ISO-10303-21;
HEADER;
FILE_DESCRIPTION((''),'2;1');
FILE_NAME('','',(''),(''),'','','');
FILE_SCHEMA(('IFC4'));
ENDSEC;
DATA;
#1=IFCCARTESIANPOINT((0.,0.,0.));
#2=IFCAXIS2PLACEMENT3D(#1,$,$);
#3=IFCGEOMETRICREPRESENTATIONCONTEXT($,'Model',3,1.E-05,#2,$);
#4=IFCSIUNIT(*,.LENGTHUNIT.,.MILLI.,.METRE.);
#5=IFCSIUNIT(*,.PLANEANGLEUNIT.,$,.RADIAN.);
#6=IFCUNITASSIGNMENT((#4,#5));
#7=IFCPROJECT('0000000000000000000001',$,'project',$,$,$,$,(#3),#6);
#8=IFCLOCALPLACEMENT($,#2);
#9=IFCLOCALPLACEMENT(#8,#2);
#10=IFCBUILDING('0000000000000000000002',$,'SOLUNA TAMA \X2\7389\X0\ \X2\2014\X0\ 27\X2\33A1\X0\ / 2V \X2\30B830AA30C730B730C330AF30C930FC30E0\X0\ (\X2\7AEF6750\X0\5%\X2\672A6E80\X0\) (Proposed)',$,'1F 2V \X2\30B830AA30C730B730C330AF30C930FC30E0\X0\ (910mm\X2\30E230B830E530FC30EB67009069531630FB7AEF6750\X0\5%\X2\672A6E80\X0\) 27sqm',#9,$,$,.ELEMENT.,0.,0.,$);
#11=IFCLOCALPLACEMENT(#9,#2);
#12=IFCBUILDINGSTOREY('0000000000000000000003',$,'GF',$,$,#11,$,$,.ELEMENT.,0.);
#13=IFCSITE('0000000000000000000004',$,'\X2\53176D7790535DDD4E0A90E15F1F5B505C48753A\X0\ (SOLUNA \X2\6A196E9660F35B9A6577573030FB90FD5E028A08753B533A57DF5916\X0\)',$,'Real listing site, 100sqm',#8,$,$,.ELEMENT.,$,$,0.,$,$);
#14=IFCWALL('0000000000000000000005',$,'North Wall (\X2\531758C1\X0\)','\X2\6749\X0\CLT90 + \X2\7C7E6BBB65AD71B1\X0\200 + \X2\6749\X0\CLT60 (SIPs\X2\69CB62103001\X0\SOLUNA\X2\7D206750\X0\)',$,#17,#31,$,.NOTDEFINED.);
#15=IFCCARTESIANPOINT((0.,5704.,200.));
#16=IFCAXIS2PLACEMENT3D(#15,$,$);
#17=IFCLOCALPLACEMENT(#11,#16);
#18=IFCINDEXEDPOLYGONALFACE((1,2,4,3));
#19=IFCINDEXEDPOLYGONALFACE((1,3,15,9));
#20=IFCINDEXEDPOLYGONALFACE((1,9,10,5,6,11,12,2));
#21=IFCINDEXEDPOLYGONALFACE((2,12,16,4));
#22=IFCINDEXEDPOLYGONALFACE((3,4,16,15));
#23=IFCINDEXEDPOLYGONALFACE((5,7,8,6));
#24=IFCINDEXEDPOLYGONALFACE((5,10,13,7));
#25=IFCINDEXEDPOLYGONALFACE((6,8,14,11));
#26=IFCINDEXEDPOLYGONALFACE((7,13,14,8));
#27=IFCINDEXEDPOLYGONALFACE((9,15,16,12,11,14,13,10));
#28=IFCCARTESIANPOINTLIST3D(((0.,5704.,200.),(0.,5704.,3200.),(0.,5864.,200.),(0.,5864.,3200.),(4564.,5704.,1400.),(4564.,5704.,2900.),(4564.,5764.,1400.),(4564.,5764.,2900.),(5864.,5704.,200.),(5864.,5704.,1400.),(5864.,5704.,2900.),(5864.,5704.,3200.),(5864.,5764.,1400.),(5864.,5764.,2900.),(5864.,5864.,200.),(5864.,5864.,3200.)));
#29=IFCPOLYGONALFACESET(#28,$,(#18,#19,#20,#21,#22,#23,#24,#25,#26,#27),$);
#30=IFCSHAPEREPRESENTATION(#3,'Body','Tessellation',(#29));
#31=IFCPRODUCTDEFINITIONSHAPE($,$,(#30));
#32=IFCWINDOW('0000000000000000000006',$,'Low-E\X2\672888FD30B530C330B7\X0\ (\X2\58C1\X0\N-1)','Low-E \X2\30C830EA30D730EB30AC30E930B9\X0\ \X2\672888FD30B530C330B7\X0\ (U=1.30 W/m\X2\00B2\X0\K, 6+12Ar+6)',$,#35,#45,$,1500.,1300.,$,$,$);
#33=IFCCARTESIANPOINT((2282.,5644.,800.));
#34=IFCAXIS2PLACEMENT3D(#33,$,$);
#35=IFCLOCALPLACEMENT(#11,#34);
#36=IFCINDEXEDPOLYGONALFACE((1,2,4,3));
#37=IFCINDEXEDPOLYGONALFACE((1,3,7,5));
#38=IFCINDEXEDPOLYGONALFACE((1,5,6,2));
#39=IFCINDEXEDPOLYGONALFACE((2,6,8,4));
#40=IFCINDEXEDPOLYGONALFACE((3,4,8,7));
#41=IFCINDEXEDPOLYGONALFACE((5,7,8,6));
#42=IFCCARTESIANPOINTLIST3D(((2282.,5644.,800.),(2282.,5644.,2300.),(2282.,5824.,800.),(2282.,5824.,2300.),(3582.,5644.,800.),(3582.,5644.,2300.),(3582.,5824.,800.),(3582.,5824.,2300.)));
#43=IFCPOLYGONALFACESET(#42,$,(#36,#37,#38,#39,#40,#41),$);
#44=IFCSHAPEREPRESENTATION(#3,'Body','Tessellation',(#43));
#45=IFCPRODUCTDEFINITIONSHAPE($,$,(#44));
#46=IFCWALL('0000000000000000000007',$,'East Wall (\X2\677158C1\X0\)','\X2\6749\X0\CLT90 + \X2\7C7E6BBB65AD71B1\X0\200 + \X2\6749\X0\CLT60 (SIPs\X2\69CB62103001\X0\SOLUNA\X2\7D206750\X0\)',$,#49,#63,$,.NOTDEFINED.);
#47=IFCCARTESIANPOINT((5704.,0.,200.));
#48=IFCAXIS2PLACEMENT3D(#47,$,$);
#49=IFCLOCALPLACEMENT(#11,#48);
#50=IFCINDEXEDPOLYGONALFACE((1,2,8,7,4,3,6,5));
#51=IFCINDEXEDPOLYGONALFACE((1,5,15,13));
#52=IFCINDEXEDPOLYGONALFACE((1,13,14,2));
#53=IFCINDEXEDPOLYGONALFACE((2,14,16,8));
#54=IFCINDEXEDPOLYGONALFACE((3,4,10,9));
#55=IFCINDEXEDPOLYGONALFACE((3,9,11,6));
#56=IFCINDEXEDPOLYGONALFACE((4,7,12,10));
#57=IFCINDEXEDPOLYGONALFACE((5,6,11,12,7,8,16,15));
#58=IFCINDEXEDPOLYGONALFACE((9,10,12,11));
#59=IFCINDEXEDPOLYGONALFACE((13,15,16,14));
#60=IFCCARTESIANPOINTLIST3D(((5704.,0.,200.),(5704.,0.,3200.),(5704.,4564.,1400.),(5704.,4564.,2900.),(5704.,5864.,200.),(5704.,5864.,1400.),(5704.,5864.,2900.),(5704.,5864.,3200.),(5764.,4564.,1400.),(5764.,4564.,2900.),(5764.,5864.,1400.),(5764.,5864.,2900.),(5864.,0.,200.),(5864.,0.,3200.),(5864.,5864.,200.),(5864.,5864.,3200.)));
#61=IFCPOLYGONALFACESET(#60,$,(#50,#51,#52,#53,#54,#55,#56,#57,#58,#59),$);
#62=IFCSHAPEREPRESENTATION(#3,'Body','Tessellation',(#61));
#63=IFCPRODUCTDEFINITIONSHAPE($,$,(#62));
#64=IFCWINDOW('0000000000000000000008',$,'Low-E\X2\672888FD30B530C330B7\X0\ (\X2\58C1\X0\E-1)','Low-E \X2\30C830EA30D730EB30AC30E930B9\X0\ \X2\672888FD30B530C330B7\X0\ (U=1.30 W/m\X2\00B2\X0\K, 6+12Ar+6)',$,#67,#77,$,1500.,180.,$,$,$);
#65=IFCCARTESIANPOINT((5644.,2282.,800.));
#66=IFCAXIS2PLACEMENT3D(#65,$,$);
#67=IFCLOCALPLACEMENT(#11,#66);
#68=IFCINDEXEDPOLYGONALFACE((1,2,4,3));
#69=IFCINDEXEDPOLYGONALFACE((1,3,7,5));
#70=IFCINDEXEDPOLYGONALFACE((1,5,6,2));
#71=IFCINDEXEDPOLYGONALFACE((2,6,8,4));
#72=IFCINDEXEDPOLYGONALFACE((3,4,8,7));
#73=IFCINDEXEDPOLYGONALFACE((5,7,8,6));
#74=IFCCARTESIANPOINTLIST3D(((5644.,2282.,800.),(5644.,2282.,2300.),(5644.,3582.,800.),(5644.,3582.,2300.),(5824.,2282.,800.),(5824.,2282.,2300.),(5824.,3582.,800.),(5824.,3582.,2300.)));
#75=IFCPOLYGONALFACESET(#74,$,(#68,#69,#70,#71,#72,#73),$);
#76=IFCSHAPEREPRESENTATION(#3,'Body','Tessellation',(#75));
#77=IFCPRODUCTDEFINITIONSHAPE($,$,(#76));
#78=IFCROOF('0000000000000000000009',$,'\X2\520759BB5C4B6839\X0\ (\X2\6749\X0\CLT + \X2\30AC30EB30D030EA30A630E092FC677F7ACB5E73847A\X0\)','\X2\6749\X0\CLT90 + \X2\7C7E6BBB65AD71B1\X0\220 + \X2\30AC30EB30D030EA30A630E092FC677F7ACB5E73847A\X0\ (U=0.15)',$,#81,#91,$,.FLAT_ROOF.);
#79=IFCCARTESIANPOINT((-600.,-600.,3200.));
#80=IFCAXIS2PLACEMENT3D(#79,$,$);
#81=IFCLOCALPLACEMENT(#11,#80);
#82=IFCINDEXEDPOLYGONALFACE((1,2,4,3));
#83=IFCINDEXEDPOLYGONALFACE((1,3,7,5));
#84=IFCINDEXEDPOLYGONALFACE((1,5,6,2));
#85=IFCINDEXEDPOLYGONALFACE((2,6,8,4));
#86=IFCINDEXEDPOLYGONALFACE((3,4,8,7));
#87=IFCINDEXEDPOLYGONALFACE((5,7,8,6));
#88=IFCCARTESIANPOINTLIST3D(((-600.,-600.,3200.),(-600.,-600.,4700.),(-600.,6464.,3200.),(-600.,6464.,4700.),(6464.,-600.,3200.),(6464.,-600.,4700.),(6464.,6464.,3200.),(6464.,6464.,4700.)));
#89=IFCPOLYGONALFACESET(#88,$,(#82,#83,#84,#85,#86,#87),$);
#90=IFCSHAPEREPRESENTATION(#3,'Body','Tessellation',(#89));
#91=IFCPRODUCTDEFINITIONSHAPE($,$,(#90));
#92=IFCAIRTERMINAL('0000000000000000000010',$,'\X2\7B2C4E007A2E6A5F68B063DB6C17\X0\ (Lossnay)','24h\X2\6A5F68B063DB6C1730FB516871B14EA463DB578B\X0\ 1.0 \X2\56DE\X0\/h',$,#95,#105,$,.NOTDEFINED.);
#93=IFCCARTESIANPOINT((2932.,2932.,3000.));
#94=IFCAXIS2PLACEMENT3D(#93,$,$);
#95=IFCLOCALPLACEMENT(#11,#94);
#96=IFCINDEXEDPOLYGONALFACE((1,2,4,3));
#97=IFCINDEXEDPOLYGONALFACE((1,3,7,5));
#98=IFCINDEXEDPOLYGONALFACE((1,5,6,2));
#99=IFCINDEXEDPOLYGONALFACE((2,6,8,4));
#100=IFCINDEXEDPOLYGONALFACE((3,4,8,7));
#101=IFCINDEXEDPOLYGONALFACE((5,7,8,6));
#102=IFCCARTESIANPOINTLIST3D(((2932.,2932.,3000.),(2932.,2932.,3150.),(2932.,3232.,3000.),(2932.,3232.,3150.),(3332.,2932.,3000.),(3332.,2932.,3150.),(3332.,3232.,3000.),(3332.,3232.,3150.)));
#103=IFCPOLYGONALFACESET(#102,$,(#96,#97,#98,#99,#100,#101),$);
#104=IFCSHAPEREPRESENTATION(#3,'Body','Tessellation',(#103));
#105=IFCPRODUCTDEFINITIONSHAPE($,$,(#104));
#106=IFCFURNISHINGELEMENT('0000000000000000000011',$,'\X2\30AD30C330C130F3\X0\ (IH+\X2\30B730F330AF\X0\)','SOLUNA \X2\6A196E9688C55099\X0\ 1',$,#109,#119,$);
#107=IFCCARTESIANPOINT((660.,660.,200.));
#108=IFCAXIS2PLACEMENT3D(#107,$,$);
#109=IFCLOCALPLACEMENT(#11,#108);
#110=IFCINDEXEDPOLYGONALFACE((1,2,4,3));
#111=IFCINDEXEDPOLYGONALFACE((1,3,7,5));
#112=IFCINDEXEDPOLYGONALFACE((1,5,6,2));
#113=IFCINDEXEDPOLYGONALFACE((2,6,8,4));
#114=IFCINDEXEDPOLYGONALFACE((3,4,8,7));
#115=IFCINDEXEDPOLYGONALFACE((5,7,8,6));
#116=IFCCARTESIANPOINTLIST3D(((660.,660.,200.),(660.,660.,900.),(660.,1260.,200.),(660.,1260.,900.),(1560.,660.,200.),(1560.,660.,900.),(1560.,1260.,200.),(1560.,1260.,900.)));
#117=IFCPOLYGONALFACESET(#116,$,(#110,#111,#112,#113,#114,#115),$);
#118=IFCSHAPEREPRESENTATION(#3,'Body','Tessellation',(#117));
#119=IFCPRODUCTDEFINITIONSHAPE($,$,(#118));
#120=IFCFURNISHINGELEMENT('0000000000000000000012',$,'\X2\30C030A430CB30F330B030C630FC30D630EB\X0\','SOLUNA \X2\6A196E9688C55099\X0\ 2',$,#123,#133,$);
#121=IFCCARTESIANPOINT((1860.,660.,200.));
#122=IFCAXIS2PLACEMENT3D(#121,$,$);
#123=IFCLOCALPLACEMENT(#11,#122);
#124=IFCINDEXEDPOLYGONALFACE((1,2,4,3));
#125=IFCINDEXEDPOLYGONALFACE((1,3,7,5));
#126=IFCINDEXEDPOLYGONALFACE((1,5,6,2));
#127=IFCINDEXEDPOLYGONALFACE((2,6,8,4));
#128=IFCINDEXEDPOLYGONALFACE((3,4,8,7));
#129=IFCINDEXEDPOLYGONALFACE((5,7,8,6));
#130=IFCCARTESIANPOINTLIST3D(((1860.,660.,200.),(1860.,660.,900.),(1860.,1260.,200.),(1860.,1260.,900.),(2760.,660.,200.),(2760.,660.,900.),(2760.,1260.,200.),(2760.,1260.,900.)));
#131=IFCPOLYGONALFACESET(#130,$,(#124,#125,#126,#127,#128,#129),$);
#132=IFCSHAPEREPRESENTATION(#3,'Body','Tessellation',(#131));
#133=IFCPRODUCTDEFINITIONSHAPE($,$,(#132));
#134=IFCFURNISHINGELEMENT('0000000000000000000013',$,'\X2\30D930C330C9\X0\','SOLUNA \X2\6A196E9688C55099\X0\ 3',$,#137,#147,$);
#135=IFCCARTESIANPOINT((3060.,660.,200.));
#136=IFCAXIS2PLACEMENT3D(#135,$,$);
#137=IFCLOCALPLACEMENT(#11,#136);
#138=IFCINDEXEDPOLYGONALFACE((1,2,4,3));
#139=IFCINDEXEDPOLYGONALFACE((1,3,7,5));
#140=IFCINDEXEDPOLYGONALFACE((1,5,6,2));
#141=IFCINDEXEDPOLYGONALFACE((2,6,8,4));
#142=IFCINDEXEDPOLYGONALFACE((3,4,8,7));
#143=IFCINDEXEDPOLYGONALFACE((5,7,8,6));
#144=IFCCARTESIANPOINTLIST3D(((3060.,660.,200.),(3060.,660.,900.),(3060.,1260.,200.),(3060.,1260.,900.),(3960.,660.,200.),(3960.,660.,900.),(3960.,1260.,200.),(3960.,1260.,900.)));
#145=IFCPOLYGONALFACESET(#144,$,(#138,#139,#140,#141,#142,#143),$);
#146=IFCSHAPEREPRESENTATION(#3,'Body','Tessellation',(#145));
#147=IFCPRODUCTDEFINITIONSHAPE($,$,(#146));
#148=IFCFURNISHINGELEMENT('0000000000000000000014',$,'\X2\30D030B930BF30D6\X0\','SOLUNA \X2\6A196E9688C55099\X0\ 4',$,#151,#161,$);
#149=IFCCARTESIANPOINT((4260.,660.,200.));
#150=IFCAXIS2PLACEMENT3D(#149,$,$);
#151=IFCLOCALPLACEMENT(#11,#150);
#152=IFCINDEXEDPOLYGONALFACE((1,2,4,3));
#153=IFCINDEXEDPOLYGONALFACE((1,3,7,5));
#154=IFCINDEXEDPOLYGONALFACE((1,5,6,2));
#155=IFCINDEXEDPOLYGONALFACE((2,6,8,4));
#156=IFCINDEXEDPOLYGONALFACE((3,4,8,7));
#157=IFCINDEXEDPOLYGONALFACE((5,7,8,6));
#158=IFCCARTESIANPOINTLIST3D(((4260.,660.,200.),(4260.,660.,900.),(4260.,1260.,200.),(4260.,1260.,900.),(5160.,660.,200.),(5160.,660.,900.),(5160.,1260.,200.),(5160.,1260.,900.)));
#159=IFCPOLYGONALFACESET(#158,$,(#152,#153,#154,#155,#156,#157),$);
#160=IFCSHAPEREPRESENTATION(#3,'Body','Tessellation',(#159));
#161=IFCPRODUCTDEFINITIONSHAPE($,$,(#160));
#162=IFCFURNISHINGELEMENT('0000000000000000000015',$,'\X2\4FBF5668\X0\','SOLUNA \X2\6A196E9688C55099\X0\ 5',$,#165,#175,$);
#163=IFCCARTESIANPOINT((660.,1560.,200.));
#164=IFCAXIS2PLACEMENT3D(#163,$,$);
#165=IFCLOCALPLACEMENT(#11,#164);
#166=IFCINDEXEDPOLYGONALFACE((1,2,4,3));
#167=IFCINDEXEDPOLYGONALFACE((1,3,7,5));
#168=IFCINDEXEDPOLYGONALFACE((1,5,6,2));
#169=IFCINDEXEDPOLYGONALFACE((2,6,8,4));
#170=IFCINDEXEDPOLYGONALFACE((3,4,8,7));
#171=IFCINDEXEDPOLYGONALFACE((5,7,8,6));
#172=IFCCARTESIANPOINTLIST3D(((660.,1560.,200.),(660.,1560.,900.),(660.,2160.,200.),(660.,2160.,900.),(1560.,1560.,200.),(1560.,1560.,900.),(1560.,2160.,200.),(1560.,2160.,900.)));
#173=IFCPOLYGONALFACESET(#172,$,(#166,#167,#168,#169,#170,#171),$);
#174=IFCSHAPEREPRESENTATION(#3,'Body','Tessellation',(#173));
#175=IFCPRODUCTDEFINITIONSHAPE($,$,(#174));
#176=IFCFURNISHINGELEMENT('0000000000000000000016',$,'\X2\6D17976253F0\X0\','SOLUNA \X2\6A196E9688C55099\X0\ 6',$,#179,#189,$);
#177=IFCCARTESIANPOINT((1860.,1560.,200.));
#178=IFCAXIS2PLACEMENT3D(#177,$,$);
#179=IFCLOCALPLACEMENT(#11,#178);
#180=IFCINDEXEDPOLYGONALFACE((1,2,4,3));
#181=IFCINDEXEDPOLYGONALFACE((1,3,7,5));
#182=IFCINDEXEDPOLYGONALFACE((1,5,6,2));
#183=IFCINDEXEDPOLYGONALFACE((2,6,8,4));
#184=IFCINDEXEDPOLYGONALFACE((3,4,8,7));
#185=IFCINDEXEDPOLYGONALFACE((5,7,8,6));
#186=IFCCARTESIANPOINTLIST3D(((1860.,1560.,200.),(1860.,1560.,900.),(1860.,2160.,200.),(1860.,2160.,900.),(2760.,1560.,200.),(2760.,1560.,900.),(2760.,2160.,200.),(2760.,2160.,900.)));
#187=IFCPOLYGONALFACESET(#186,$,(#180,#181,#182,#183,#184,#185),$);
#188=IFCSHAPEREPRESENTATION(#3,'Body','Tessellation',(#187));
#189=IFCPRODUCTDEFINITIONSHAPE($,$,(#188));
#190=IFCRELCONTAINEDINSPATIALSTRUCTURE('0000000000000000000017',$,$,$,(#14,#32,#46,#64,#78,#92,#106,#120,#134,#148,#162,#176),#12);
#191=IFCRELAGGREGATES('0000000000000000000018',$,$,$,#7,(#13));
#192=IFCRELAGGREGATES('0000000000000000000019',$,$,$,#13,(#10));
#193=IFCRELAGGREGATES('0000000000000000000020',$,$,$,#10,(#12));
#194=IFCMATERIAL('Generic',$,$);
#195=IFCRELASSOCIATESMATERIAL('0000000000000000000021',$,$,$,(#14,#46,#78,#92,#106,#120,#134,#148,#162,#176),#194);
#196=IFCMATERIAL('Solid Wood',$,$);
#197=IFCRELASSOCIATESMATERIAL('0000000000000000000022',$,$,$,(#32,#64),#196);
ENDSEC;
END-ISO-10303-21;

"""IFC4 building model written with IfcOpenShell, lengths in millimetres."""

from ifc_helpers import new_model, si_unit, frame, frame_2d, origin, place, context, project, spatial, rectangle, extrude, material, element, fill, save


model = new_model("IFC4")

# Units and contexts
model_context = context("Model", 3, precision=1e-05, world=origin())
ifc_project = project(units=[si_unit("LENGTHUNIT", "METRE", prefix="MILLI"), si_unit("PLANEANGLEUNIT", "RADIAN")], contexts=[model_context])

# Site, building, storey
site_placement = place(None, origin())
site = spatial("IfcSite", under=ifc_project, at=site_placement, Name="北海道川上郡弟子屈町 (SOLUNA 標準想定敷地・都市計画区域外)", ObjectType="Real listing site, 100sqm", CompositionType="ELEMENT", RefElevation=0.0)
building_placement = place(site_placement, origin())
building = spatial("IfcBuilding", under=site, at=building_placement, Name="SOLUNA TAMA 玉 — 27㎡ / 2V ジオデシックドーム (端材5%未満) (Proposed)", ObjectType="1F 2V ジオデシックドーム (910mmモジュール最適化・端材5%未満) 27sqm", CompositionType="ELEMENT", ElevationOfRefHeight=0.0, ElevationOfTerrain=0.0)
storey_placement = place(building_placement, origin())
storey = spatial("IfcBuildingStorey", under=building, at=storey_placement, Name="GF", CompositionType="ELEMENT", Elevation=0.0)

# Shared definitions
ifc_material_1 = material(Name="Generic")

# Shared definitions
ifc_material_2 = material(Name="Solid Wood")

# Walls, openings, windows
wall_1_placement = place(storey_placement, frame((0.0, 5704.0, 200.0)))
wall_1 = element("IfcWall", 1, at=wall_1_placement, inside=storey, material=ifc_material_1, Name="North Wall (北壁)", Description="杉CLT90 + 籾殻断熱200 + 杉CLT60 (SIPs構成、SOLUNA素材)", PredefinedType="NOTDEFINED", context=model_context, shape_type="SweptSolid", body=[
    extrude(rectangle(XDim=5864.0, YDim=160.0, at=frame_2d((2932.0, 80.0))), frame((0.0, 5704.0, 200.0)), (0.0, 0.0, 1.0), 3000.0),
])
opening_1_placement = place(storey_placement, frame((2282.0, 5644.0, 800.0)))
opening_1 = element("IfcOpeningElement", 2, at=opening_1_placement, cuts=wall_1, PredefinedType="NOTDEFINED", context=model_context, shape_type="SweptSolid", body=[
    extrude(rectangle(XDim=1300.0, YDim=180.0, at=frame_2d((650.0, 90.0))), frame((2282.0, 5644.0, 800.0)), (0.0, 0.0, 1.0), 1500.0),
])
window_1_placement = place(storey_placement, frame((2282.0, 5644.0, 800.0)))
window_1 = element("IfcWindow", 3, at=window_1_placement, inside=storey, material=ifc_material_2, Name="Low-E木製サッシ (壁N-1)", Description="Low-E トリプルガラス 木製サッシ (U=1.30 W/m²K, 6+12Ar+6)", OverallHeight=1500.0, OverallWidth=1300.0, context=model_context, shape_type="SweptSolid", body=[
    extrude(rectangle(XDim=1300.0, YDim=180.0, at=frame_2d((650.0, 90.0))), frame((2282.0, 5644.0, 800.0)), (0.0, 0.0, 1.0), 1500.0),
])
fill(opening_1, window_1)
wall_2_placement = place(storey_placement, frame((5704.0, 0.0, 200.0)))
wall_2 = element("IfcWall", 4, at=wall_2_placement, inside=storey, material=ifc_material_1, Name="East Wall (東壁)", Description="杉CLT90 + 籾殻断熱200 + 杉CLT60 (SIPs構成、SOLUNA素材)", PredefinedType="NOTDEFINED", context=model_context, shape_type="SweptSolid", body=[
    extrude(rectangle(XDim=160.0, YDim=5864.0, at=frame_2d((80.0, 2932.0))), frame((5704.0, 0.0, 200.0)), (0.0, 0.0, 1.0), 3000.0),
])
opening_2_placement = place(storey_placement, frame((5644.0, 2282.0, 800.0)))
opening_2 = element("IfcOpeningElement", 5, at=opening_2_placement, cuts=wall_2, PredefinedType="NOTDEFINED", context=model_context, shape_type="SweptSolid", body=[
    extrude(rectangle(XDim=180.0, YDim=1300.0, at=frame_2d((90.0, 650.0))), frame((5644.0, 2282.0, 800.0)), (0.0, 0.0, 1.0), 1500.0),
])
window_2_placement = place(storey_placement, frame((5644.0, 2282.0, 800.0)))
window_2 = element("IfcWindow", 6, at=window_2_placement, inside=storey, material=ifc_material_2, Name="Low-E木製サッシ (壁E-1)", Description="Low-E トリプルガラス 木製サッシ (U=1.30 W/m²K, 6+12Ar+6)", OverallHeight=1500.0, OverallWidth=180.0, context=model_context, shape_type="SweptSolid", body=[
    extrude(rectangle(XDim=180.0, YDim=1300.0, at=frame_2d((90.0, 650.0))), frame((5644.0, 2282.0, 800.0)), (0.0, 0.0, 1.0), 1500.0),
])
fill(opening_2, window_2)

# Roof
roof_placement = place(storey_placement, frame((-600.0, -600.0, 3200.0)))
element("IfcRoof", 7, at=roof_placement, inside=storey, material=ifc_material_1, Name="切妻屋根 (杉CLT + ガルバリウム鋼板立平葺)", Description="杉CLT90 + 籾殻断熱220 + ガルバリウム鋼板立平葺 (U=0.15)", PredefinedType="FLAT_ROOF", context=model_context, shape_type="SweptSolid", body=[
    extrude(rectangle(XDim=7064.0, YDim=7064.0, at=frame_2d((3532.0, 3532.0))), frame((-600.0, -600.0, 3200.0)), (0.0, 0.0, 1.0), 1500.0),
])

# Air terminal
air_terminal_placement = place(storey_placement, frame((2932.0, 2932.0, 3000.0)))
element("IfcAirTerminal", 8, at=air_terminal_placement, inside=storey, material=ifc_material_1, Name="第一種機械換気 (Lossnay)", Description="24h機械換気・全熱交換型 1.0 回/h", PredefinedType="NOTDEFINED", context=model_context, shape_type="SweptSolid", body=[
    extrude(rectangle(XDim=400.0, YDim=300.0, at=frame_2d((200.0, 150.0))), frame((2932.0, 2932.0, 3000.0)), (0.0, 0.0, 1.0), 150.0),
])

# Furnishing elements
furnishing_1_placement = place(storey_placement, frame((660.0, 660.0, 200.0)))
element("IfcFurnishingElement", 9, at=furnishing_1_placement, inside=storey, material=ifc_material_1, Name="キッチン (IH+シンク)", Description="SOLUNA 標準装備 1", context=model_context, shape_type="SweptSolid", body=[
    extrude(rectangle(XDim=900.0, YDim=600.0, at=frame_2d((450.0, 300.0))), frame((660.0, 660.0, 200.0)), (0.0, 0.0, 1.0), 700.0),
])
furnishing_2_placement = place(storey_placement, frame((1860.0, 660.0, 200.0)))
element("IfcFurnishingElement", 10, at=furnishing_2_placement, inside=storey, material=ifc_material_1, Name="ダイニングテーブル", Description="SOLUNA 標準装備 2", context=model_context, shape_type="SweptSolid", body=[
    extrude(rectangle(XDim=900.0, YDim=600.0, at=frame_2d((450.0, 300.0))), frame((1860.0, 660.0, 200.0)), (0.0, 0.0, 1.0), 700.0),
])
furnishing_3_placement = place(storey_placement, frame((3060.0, 660.0, 200.0)))
element("IfcFurnishingElement", 11, at=furnishing_3_placement, inside=storey, material=ifc_material_1, Name="ベッド", Description="SOLUNA 標準装備 3", context=model_context, shape_type="SweptSolid", body=[
    extrude(rectangle(XDim=900.0, YDim=600.0, at=frame_2d((450.0, 300.0))), frame((3060.0, 660.0, 200.0)), (0.0, 0.0, 1.0), 700.0),
])
furnishing_4_placement = place(storey_placement, frame((4260.0, 660.0, 200.0)))
element("IfcFurnishingElement", 12, at=furnishing_4_placement, inside=storey, material=ifc_material_1, Name="バスタブ", Description="SOLUNA 標準装備 4", context=model_context, shape_type="SweptSolid", body=[
    extrude(rectangle(XDim=900.0, YDim=600.0, at=frame_2d((450.0, 300.0))), frame((4260.0, 660.0, 200.0)), (0.0, 0.0, 1.0), 700.0),
])
furnishing_5_placement = place(storey_placement, frame((660.0, 1560.0, 200.0)))
element("IfcFurnishingElement", 13, at=furnishing_5_placement, inside=storey, material=ifc_material_1, Name="便器", Description="SOLUNA 標準装備 5", context=model_context, shape_type="SweptSolid", body=[
    extrude(rectangle(XDim=900.0, YDim=600.0, at=frame_2d((450.0, 300.0))), frame((660.0, 1560.0, 200.0)), (0.0, 0.0, 1.0), 700.0),
])
furnishing_6_placement = place(storey_placement, frame((1860.0, 1560.0, 200.0)))
element("IfcFurnishingElement", 14, at=furnishing_6_placement, inside=storey, material=ifc_material_1, Name="洗面台", Description="SOLUNA 標準装備 6", context=model_context, shape_type="SweptSolid", body=[
    extrude(rectangle(XDim=900.0, YDim=600.0, at=frame_2d((450.0, 300.0))), frame((1860.0, 1560.0, 200.0)), (0.0, 0.0, 1.0), 700.0),
])

save(model, "model.ifc")
